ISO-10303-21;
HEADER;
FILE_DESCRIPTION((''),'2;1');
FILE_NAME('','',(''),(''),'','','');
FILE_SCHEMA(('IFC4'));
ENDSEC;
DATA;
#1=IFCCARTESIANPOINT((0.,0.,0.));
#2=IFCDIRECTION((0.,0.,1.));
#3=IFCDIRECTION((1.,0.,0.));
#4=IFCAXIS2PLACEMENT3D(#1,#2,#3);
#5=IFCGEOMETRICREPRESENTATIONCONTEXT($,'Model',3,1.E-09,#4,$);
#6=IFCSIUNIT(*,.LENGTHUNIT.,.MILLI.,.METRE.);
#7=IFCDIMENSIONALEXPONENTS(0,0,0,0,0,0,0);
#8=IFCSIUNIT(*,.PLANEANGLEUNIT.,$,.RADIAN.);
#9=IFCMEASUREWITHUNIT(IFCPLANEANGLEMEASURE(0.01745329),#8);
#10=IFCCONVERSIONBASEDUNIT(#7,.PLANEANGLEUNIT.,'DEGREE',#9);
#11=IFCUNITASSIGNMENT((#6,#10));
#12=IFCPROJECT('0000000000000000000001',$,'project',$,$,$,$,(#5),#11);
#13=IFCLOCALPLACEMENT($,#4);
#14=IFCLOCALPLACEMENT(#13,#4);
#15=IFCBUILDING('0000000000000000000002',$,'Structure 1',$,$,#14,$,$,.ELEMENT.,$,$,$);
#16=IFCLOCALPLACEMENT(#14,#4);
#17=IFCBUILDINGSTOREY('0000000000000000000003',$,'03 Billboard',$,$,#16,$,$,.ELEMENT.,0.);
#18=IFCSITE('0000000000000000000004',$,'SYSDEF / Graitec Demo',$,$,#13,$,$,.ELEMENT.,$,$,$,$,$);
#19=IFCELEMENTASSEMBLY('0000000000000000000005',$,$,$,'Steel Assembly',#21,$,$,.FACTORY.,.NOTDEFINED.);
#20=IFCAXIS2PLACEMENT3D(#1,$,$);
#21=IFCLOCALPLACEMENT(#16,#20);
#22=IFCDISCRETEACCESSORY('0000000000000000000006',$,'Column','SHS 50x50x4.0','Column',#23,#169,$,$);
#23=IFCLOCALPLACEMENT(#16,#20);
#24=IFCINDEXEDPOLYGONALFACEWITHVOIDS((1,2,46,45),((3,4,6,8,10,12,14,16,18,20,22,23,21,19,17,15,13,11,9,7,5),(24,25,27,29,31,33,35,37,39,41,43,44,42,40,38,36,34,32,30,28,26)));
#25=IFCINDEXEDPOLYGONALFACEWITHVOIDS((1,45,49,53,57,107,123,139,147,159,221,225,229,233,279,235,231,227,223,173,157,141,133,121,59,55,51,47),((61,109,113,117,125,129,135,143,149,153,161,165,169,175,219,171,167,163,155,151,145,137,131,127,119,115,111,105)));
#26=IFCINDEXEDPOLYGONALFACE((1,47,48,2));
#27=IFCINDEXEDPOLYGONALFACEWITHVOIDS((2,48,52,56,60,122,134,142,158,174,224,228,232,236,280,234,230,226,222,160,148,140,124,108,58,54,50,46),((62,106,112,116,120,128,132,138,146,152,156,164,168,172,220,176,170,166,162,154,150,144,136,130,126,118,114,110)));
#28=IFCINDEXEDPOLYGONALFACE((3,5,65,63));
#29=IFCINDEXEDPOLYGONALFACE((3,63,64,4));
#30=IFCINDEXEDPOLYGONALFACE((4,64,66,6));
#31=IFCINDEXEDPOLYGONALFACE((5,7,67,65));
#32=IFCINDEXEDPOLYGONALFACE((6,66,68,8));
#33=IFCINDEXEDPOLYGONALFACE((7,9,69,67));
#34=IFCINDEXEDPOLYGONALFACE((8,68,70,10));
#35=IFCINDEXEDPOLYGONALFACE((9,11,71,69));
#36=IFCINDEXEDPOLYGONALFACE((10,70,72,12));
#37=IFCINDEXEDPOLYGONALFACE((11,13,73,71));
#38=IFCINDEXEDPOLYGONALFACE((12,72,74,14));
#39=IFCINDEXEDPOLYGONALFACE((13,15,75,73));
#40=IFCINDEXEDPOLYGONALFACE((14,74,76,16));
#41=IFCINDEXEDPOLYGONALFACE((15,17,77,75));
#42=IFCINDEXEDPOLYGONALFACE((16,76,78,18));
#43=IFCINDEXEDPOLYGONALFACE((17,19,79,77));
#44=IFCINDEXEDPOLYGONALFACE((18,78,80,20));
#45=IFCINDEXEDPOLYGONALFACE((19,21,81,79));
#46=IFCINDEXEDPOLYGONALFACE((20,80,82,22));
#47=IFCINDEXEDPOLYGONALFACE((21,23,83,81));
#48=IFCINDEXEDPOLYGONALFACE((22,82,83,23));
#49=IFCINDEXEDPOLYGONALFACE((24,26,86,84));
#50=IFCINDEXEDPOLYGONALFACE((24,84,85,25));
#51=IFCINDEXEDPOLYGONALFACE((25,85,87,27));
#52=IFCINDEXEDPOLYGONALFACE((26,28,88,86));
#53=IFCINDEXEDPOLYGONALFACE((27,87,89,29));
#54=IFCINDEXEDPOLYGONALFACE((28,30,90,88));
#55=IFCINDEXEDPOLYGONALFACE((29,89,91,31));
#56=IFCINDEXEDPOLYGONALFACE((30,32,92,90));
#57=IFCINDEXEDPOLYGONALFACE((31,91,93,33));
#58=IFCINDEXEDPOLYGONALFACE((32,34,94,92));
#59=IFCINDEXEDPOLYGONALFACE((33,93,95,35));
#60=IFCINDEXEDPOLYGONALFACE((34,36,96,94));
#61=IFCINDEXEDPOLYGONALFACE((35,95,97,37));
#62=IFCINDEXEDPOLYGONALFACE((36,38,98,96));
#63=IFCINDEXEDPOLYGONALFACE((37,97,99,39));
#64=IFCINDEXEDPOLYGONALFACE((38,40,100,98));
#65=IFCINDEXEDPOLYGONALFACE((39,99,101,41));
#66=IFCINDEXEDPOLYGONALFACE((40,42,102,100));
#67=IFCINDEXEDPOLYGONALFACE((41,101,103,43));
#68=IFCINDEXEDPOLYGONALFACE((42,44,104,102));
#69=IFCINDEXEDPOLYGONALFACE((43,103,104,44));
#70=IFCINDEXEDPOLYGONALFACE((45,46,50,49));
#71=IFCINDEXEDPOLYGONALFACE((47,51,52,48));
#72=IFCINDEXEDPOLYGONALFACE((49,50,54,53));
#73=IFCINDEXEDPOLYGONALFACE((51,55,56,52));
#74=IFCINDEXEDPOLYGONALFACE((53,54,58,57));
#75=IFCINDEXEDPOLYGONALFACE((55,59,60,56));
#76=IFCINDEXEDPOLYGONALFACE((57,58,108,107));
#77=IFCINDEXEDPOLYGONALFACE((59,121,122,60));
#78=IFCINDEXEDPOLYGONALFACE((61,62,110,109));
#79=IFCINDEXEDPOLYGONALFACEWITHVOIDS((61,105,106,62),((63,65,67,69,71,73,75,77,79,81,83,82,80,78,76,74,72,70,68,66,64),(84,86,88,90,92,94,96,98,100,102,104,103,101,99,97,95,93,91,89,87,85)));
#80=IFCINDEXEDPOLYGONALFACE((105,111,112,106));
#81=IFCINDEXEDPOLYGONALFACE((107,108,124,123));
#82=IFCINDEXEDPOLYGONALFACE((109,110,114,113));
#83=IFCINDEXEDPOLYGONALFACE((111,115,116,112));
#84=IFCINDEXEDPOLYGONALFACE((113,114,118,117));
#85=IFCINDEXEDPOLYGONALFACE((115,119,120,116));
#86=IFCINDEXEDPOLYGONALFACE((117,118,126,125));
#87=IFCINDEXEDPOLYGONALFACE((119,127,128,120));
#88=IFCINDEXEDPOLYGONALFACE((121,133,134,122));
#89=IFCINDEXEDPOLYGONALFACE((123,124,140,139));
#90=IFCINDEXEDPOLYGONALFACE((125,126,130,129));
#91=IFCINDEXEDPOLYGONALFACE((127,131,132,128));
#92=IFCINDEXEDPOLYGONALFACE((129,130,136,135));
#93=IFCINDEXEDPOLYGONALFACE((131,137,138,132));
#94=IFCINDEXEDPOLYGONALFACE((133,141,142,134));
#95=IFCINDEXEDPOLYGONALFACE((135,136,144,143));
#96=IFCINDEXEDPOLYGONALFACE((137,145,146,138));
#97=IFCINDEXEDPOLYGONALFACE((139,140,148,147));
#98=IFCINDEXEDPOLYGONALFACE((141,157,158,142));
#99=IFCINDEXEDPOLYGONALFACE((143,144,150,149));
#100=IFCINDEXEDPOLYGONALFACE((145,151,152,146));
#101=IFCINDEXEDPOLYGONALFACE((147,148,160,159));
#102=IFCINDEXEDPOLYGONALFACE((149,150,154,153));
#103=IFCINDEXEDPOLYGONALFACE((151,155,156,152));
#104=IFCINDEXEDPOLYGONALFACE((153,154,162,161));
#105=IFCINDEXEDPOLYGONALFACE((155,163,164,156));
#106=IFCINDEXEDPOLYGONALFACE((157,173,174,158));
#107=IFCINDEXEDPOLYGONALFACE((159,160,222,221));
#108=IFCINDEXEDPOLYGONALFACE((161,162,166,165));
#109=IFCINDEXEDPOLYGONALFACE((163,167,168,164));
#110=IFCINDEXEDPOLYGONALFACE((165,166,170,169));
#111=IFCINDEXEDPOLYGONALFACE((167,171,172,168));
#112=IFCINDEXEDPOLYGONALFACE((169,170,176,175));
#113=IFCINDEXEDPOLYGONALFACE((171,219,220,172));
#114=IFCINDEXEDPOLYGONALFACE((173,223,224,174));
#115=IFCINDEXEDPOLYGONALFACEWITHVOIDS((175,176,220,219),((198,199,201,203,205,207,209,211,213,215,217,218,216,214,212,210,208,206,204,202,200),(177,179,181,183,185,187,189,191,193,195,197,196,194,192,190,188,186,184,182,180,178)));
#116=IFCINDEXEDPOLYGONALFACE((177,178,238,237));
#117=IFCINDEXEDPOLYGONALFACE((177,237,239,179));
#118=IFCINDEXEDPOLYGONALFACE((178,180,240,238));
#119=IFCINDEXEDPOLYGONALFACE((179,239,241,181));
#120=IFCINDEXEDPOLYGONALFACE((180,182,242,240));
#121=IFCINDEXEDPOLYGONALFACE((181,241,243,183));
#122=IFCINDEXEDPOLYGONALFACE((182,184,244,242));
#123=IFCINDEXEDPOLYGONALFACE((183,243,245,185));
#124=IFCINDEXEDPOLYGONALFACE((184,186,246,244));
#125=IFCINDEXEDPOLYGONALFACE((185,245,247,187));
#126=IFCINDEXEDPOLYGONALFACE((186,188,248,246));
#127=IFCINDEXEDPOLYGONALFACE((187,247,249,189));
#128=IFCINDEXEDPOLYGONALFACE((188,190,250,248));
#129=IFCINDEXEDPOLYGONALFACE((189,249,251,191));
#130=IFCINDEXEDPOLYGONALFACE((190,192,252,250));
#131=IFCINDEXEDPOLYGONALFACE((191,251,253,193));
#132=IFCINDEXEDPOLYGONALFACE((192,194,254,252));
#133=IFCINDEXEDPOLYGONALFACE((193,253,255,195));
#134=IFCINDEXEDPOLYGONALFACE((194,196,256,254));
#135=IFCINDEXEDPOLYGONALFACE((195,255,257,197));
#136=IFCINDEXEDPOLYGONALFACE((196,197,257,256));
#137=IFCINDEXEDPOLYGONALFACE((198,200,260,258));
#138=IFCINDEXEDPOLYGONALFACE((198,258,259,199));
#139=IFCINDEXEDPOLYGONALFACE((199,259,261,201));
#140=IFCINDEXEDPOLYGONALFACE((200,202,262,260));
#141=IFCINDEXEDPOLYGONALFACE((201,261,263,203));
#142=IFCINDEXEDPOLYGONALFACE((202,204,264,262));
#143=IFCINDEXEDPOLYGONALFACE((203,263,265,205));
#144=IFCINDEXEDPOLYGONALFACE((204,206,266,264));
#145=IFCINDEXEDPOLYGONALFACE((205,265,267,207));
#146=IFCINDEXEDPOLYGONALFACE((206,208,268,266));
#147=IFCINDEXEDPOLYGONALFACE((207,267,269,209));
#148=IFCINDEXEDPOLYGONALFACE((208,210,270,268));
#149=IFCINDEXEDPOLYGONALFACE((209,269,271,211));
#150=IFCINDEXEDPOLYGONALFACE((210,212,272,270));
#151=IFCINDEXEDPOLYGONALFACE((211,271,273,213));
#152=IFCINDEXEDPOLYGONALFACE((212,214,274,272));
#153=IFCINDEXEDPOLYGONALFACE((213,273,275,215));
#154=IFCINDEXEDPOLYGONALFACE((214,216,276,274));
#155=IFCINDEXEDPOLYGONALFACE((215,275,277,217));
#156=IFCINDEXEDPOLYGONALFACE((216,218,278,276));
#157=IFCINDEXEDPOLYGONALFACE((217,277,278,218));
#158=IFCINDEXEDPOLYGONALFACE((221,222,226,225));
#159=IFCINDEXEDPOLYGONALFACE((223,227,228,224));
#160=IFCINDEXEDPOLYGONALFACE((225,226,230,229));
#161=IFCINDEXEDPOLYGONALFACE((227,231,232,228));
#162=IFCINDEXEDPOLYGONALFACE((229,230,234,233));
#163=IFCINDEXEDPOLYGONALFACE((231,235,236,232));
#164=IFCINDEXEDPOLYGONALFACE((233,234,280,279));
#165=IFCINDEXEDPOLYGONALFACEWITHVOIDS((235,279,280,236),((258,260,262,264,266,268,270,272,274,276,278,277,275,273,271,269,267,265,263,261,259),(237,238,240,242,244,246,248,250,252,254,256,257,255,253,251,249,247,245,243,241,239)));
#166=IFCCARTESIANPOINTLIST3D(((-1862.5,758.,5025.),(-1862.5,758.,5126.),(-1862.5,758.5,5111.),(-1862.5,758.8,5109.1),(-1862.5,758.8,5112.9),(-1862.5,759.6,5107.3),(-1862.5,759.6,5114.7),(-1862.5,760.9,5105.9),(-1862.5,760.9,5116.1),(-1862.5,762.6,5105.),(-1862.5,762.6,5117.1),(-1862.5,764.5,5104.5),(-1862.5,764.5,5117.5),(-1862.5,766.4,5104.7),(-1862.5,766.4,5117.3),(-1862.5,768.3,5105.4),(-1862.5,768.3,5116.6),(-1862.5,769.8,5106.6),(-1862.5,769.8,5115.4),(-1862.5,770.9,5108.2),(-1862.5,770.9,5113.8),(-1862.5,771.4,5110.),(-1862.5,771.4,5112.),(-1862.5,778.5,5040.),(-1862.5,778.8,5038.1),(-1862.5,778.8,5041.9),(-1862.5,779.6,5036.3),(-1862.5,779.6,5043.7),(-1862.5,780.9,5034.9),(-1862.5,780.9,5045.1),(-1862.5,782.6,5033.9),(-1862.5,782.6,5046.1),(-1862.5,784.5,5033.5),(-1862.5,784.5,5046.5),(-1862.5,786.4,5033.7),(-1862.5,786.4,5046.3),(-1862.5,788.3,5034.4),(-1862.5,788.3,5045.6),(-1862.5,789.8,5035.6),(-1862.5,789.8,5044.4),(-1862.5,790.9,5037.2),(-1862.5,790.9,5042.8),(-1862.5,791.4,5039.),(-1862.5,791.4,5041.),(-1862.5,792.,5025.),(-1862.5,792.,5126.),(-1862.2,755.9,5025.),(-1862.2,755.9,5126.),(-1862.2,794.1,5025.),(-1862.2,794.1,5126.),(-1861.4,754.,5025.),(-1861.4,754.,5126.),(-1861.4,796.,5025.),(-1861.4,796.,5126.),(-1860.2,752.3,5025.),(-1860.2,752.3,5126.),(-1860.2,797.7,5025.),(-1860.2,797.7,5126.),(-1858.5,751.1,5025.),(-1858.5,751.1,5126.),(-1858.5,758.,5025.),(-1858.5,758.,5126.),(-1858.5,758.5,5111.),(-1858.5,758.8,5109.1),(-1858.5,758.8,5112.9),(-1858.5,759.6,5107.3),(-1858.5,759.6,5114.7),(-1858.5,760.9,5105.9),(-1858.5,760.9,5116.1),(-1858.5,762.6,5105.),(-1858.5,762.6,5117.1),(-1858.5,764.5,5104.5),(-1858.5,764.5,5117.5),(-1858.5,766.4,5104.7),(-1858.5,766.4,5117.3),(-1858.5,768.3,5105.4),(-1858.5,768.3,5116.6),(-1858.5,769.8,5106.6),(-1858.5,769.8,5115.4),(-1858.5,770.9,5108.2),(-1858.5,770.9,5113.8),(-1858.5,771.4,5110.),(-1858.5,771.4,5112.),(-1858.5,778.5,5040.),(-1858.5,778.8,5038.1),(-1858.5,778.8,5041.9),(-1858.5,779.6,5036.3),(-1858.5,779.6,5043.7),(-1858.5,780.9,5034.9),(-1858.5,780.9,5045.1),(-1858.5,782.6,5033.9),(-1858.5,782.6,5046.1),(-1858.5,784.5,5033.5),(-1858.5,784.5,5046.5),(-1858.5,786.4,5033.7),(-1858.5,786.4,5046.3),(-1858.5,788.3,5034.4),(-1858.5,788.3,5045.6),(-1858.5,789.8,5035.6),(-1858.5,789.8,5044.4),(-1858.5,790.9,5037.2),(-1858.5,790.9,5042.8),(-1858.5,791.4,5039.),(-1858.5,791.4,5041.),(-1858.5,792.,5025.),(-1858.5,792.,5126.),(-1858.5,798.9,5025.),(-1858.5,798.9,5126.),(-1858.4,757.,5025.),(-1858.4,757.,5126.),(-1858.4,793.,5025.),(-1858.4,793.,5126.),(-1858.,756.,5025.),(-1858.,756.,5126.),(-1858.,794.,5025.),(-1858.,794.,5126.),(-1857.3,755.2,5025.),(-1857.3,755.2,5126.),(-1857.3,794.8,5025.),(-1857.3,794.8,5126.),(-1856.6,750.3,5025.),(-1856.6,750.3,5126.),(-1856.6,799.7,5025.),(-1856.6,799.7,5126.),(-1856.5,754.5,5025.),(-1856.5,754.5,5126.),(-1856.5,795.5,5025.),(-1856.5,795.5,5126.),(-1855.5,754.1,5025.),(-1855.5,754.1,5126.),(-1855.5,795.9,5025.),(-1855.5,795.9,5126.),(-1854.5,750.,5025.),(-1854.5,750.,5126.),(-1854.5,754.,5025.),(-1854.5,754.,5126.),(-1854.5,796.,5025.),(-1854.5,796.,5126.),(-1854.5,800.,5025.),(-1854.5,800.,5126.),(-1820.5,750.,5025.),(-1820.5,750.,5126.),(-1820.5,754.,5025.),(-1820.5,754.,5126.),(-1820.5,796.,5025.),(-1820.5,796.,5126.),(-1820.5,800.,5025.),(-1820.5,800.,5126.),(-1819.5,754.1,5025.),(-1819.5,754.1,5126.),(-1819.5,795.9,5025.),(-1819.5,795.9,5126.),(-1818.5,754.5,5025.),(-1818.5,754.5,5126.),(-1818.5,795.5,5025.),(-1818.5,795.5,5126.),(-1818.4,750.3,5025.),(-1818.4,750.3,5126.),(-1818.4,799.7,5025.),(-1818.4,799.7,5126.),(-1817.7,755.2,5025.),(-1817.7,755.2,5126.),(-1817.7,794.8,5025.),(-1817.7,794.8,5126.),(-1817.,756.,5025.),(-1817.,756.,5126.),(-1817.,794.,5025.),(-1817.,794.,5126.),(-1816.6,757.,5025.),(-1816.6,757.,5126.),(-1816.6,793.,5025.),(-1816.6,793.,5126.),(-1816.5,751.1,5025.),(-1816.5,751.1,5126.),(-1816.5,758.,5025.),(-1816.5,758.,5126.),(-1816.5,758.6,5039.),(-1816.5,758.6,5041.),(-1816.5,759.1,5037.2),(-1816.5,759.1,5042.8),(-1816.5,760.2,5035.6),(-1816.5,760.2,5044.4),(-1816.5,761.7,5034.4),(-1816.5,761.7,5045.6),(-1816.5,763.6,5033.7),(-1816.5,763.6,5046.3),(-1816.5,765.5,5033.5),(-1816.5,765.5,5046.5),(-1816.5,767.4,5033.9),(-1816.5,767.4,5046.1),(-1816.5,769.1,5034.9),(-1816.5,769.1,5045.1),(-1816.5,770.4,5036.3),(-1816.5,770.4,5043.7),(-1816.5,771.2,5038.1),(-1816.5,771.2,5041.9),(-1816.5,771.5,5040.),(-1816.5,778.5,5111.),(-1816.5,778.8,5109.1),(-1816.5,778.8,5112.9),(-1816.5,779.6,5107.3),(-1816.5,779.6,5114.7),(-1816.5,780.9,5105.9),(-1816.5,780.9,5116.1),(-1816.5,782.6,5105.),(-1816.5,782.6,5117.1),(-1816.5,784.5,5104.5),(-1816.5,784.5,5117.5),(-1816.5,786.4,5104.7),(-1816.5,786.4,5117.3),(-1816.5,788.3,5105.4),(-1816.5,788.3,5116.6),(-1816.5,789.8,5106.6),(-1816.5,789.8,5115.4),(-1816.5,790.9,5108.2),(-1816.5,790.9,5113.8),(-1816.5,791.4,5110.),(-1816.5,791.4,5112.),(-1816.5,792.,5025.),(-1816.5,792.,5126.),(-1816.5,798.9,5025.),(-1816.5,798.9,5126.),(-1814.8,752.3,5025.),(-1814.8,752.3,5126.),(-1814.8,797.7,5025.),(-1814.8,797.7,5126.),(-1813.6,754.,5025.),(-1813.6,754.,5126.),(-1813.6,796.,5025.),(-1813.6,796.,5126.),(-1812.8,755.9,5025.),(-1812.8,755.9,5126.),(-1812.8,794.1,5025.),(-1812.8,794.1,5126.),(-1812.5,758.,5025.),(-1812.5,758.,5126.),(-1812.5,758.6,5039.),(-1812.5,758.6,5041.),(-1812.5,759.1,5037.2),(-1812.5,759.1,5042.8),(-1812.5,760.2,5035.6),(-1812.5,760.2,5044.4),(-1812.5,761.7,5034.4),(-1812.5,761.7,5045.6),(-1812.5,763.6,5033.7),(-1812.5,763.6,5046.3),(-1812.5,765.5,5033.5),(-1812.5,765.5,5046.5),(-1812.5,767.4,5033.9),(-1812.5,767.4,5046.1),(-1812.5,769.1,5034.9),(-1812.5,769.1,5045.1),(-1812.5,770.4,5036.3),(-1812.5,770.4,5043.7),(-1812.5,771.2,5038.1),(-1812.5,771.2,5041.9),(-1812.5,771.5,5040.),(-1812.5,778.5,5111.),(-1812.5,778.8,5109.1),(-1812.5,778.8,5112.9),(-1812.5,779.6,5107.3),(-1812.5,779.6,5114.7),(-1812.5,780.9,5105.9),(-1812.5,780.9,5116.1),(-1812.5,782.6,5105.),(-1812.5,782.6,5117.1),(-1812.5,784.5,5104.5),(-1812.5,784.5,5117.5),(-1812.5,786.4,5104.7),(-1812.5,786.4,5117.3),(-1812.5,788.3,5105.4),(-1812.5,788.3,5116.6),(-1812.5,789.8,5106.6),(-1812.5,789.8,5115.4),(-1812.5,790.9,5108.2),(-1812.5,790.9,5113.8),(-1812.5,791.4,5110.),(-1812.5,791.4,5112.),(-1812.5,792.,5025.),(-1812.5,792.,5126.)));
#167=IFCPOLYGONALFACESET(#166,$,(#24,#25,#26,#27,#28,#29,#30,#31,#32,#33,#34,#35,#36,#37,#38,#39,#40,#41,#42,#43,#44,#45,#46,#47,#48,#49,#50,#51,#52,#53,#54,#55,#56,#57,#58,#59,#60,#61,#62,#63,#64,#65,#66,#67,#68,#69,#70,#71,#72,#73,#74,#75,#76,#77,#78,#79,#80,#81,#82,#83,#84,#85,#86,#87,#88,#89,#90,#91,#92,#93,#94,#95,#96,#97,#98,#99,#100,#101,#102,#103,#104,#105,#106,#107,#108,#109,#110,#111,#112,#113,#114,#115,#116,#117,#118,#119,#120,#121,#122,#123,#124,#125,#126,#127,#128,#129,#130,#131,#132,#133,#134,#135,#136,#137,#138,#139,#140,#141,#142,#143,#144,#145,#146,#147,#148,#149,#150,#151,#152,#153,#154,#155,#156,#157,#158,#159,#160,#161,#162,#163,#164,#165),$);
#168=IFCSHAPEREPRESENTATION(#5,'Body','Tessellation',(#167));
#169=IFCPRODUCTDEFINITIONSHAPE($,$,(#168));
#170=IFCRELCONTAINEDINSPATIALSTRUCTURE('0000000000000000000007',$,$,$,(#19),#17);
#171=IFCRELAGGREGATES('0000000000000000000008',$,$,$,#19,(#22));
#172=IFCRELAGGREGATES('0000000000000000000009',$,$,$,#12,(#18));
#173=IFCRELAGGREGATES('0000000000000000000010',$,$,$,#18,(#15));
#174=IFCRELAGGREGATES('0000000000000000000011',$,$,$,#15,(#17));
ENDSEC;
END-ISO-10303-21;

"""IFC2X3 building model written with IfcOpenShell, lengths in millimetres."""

from ifc_helpers import new_model, entity, si_unit, converted_unit, frame, frame_2d, origin, origin_with_axes, origin_2d, origin_2d_with_axis, place, context, project, spatial, hollow_rectangle, circle, extrude, clip, halfspace, element, aggregate, save


model = new_model("IFC2X3")

# Units and contexts
model_context = context("Model", 3, precision=1e-09, world=origin_with_axes())
ifc_project = project(units=[si_unit("LENGTHUNIT", "METRE", prefix="MILLI"), converted_unit("PLANEANGLEUNIT", "DEGREE", entity("IfcPlaneAngleMeasure", 0.01745329), si_unit("PLANEANGLEUNIT", "RADIAN"), dimensions=[0, 0, 0, 0, 0, 0, 0])], contexts=[model_context])

# Site, building, storey
site_placement = place(None, origin_with_axes())
site = spatial("IfcSite", under=ifc_project, at=site_placement, Name="SYSDEF / Graitec Demo", CompositionType="ELEMENT")
building_placement = place(site_placement, origin_with_axes())
building = spatial("IfcBuilding", under=site, at=building_placement, Name="Structure 1", CompositionType="ELEMENT")
storey_placement = place(building_placement, origin_with_axes())
storey = spatial("IfcBuildingStorey", under=building, at=storey_placement, Name="03 Billboard", CompositionType="ELEMENT", Elevation=0.0)

# Element assembly, discrete accessory, openings
assembly_1_placement = place(None, frame((-4239.1, -387.5, 4000.0), z_axis=(-1.0, 0.0, 0.0), x_axis=(0.0, 0.0, 1.0)))
assembly_1 = element("IfcElementAssembly", 1, at=assembly_1_placement, inside=storey, ObjectType="Steel Assembly", AssemblyPlace="FACTORY", PredefinedType="NOTDEFINED")
discrete_accessory_1_placement = place(assembly_1_placement, frame((1186.4, 1162.5, -2401.6), z_axis=(1.0, 0.0, 0.0), x_axis=(0.0, 0.0, -1.0)))
discrete_accessory_1 = element("IfcDiscreteAccessory", 2, at=discrete_accessory_1_placement, Name="Column", Description="SHS 50x50x4.0", ObjectType="Column", context=model_context, shape_type="Clipping", body=[
    clip(clip(extrude(hollow_rectangle(XDim=50.0, YDim=50.0, WallThickness=4.0, InnerFilletRadius=4.0, OuterFilletRadius=8.0, at=origin_2d()), origin(), (0.0, 0.0, -1.0), 196.7), halfspace(frame((1837.5, -775.0, -60.4), z_axis=(0.0, 0.0, -1.0), x_axis=(-1.0, 0.0, 0.0)), True)), halfspace(frame((1837.5, -775.0, -161.4), z_axis=(0.0, 0.0, 1.0), x_axis=(1.0, 0.0, 0.0)), True)),
])
opening_1_placement = place(discrete_accessory_1_placement, frame((-25.5, 16.5, -146.4), z_axis=(-1.0, 0.0, 0.0), x_axis=(0.0, -1.0, 0.0)))
element("IfcOpeningElement", 3, at=opening_1_placement, cuts=discrete_accessory_1, ObjectType="Opening", context=model_context, shape_type="SweptSolid", body=[
    extrude(circle(Radius=6.5, at=frame_2d((6.5, 0.0), x_axis=(1.0, 0.0))), origin(), (0.0, 0.0, -1.0), 5.0),
])
opening_2_placement = place(discrete_accessory_1_placement, frame((20.5, -10.0, -146.4), z_axis=(1.0, 0.0, 0.0), x_axis=(0.0, 1.0, 0.0)))
element("IfcOpeningElement", 4, at=opening_2_placement, cuts=discrete_accessory_1, ObjectType="Opening", context=model_context, shape_type="SweptSolid", body=[
    extrude(circle(Radius=6.5, at=origin_2d_with_axis()), origin(), (0.0, 0.0, 1.0), 5.0),
])
opening_3_placement = place(discrete_accessory_1_placement, frame((-25.5, -16.5, -75.4), z_axis=(-1.0, 0.0, 0.0), x_axis=(0.0, -1.0, 0.0)))
element("IfcOpeningElement", 5, at=opening_3_placement, cuts=discrete_accessory_1, ObjectType="Opening", context=model_context, shape_type="SweptSolid", body=[
    extrude(circle(Radius=6.5, at=frame_2d((-6.5, 0.0), x_axis=(1.0, 0.0))), origin(), (0.0, 0.0, -1.0), 5.0),
])
opening_4_placement = place(discrete_accessory_1_placement, frame((20.5, 10.0, -75.4), z_axis=(1.0, 0.0, 0.0), x_axis=(0.0, -1.0, 0.0)))
element("IfcOpeningElement", 6, at=opening_4_placement, cuts=discrete_accessory_1, ObjectType="Opening", context=model_context, shape_type="SweptSolid", body=[
    extrude(circle(Radius=6.5, at=origin_2d_with_axis()), origin(), (0.0, 0.0, 1.0), 5.0),
])
aggregate(assembly_1, [discrete_accessory_1])

save(model, "model.ifc")
